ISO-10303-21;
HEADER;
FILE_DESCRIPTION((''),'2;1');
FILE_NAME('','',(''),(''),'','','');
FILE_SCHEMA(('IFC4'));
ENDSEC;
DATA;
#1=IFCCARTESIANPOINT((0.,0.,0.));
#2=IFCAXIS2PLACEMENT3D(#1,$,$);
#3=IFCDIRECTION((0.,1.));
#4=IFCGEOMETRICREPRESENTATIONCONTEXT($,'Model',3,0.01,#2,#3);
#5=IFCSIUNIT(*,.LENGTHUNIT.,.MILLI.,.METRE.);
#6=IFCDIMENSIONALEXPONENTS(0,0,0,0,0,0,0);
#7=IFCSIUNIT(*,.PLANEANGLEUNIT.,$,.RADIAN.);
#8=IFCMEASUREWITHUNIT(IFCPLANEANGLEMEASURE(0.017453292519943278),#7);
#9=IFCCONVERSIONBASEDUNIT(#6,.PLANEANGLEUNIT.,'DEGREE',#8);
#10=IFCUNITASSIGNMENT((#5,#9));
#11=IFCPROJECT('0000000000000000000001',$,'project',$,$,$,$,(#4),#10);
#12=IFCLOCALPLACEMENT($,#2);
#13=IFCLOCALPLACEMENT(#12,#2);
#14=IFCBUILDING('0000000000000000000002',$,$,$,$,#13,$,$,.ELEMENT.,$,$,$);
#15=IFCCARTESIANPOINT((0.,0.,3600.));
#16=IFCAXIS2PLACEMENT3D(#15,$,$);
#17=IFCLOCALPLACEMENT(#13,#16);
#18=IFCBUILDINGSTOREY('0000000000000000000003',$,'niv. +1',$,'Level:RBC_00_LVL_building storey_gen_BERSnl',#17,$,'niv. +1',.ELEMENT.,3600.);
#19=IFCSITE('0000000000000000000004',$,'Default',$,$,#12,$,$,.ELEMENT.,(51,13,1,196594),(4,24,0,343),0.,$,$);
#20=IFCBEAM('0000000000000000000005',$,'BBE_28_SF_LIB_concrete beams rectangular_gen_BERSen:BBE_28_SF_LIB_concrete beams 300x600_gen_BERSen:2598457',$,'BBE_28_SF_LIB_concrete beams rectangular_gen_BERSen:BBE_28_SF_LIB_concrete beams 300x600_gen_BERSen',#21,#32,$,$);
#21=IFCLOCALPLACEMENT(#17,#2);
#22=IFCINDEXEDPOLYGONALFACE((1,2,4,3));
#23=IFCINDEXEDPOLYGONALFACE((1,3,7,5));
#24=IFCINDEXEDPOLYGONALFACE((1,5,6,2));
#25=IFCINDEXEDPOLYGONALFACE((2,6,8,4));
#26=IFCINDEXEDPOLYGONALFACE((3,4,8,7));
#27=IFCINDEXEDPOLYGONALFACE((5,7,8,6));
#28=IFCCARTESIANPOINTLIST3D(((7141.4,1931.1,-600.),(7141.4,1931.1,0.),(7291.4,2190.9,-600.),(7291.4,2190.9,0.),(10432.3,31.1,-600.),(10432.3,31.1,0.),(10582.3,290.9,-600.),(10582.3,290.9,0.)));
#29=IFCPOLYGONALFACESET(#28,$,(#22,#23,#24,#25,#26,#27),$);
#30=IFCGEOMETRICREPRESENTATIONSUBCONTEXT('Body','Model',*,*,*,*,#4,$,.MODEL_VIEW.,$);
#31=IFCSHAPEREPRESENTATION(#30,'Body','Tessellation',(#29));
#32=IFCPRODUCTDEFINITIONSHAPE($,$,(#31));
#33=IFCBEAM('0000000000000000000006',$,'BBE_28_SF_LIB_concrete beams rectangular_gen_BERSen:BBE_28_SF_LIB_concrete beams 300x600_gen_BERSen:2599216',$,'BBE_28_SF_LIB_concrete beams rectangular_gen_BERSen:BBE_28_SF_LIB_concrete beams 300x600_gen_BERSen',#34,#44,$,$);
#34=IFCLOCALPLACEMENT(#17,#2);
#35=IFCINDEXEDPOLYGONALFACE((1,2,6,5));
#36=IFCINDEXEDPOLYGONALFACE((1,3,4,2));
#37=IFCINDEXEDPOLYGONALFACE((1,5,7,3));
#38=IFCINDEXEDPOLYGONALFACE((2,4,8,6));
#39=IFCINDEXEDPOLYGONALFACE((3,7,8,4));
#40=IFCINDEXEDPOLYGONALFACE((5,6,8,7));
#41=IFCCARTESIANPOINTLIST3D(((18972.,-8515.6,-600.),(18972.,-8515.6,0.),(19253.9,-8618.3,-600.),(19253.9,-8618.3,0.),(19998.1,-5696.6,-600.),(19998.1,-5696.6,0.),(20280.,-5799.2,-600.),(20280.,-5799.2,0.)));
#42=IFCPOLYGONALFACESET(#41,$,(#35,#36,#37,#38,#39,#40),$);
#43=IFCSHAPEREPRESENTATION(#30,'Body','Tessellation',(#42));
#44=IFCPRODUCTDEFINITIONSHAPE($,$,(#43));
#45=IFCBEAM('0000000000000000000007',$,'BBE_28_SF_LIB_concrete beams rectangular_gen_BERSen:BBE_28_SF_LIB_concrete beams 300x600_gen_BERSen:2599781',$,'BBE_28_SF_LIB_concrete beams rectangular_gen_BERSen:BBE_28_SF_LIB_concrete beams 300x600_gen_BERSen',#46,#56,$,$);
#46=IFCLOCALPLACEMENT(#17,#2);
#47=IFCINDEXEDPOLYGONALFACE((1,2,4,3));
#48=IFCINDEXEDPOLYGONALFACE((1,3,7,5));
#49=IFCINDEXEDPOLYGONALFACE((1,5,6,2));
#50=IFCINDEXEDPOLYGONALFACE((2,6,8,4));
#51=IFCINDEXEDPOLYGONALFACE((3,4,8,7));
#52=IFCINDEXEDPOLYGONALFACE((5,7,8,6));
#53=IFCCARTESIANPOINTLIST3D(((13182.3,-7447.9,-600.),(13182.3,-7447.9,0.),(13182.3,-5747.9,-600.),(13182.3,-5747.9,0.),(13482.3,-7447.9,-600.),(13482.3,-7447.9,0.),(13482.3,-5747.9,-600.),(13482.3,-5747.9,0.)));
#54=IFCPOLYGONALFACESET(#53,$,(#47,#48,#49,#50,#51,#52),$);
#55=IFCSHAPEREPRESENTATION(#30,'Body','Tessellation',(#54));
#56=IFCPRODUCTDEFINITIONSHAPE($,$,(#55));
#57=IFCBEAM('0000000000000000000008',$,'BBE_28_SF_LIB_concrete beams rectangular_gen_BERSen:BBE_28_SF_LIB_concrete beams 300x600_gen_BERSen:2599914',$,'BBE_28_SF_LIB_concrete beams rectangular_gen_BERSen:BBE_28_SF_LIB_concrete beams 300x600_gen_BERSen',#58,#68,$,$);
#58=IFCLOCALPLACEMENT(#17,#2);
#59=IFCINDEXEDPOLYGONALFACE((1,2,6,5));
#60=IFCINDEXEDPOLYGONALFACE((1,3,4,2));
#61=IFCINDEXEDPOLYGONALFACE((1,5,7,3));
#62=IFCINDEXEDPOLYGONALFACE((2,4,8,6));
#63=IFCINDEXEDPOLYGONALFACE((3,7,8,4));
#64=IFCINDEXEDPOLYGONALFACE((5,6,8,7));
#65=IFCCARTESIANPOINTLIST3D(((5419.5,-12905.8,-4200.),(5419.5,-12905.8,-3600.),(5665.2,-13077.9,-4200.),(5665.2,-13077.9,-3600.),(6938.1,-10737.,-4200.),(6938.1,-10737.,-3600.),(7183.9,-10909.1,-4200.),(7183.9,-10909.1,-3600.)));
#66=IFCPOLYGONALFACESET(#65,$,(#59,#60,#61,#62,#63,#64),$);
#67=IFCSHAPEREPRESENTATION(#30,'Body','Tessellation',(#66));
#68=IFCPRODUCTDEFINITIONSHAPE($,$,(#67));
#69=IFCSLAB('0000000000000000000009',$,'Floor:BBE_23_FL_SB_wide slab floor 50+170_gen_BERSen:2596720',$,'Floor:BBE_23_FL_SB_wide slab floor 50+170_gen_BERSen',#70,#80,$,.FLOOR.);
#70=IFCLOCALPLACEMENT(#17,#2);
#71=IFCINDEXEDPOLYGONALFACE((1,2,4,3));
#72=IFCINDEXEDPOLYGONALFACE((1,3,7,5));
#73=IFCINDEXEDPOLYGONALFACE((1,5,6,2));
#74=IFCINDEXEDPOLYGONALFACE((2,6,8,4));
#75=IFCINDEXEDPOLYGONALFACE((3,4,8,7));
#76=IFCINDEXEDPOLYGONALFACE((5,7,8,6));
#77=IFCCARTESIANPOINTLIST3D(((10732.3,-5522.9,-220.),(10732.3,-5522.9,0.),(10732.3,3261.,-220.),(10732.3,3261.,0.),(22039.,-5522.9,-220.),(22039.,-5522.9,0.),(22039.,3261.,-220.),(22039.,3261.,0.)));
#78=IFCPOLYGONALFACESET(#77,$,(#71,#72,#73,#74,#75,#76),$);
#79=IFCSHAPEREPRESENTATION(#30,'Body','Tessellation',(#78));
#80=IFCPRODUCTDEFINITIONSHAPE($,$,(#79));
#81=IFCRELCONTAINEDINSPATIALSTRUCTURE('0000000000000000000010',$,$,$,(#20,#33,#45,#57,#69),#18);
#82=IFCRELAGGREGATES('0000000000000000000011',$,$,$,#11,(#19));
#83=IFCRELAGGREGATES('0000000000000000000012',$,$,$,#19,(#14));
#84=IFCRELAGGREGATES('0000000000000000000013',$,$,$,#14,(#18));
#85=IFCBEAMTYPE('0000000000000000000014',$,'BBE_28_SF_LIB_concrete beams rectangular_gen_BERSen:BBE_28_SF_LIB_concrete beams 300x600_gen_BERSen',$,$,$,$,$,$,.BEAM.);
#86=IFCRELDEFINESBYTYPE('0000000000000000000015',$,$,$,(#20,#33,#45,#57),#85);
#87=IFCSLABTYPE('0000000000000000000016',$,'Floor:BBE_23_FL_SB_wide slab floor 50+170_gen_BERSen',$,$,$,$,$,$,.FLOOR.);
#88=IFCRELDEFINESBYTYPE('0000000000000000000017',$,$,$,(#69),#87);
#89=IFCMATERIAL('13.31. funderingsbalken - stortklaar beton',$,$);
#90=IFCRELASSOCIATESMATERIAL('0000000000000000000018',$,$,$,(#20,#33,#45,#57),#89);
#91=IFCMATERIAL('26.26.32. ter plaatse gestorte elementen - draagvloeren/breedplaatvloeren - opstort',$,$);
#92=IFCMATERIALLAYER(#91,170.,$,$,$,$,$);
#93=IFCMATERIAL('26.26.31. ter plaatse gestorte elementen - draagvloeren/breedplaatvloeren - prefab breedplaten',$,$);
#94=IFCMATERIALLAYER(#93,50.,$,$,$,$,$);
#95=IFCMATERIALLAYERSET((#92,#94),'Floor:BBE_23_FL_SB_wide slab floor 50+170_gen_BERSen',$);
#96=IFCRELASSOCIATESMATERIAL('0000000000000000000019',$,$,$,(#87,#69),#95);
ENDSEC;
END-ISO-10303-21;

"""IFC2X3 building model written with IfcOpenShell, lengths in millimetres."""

from ifc_helpers import new_model, entity, si_unit, converted_unit, direction, frame, frame_2d, origin, place, context, subcontext, project, spatial, rectangle, extrude, material, layer, layer_set, layer_usage, type_object, element, save


model = new_model("IFC2X3")

# Units and contexts
model_context = context("Model", 3, precision=0.01, world=origin(), true_north=direction((0.0, 1.0)))
body_context = subcontext(model_context, "Body", "Model", "MODEL_VIEW")
ifc_project = project(units=[si_unit("LENGTHUNIT", "METRE", prefix="MILLI"), converted_unit("PLANEANGLEUNIT", "DEGREE", entity("IfcPlaneAngleMeasure", 0.017453292519943278), si_unit("PLANEANGLEUNIT", "RADIAN"), dimensions=[0, 0, 0, 0, 0, 0, 0])], contexts=[model_context])

# Site, building, storey
site_placement = place(None, origin())
site = spatial("IfcSite", under=ifc_project, at=site_placement, Name="Default", CompositionType="ELEMENT", RefLatitude=(51, 13, 1, 196594), RefLongitude=(4, 24, 0, 343), RefElevation=0.0)
building_placement = place(site_placement, origin())
building = spatial("IfcBuilding", under=site, at=building_placement, CompositionType="ELEMENT")
storey_placement = place(building_placement, frame((0.0, 0.0, 3600.0)))
storey = spatial("IfcBuildingStorey", under=building, at=storey_placement, Name="niv. +1", ObjectType="Level:RBC_00_LVL_building storey_gen_BERSnl", LongName="niv. +1", CompositionType="ELEMENT", Elevation=3600.0)

# Beams
ifc_material_1 = material(Name="13.31. funderingsbalken - stortklaar beton")
beam_type = type_object("IfcBeamType", Name="BBE_28_SF_LIB_concrete beams rectangular_gen_BERSen:BBE_28_SF_LIB_concrete beams 300x600_gen_BERSen", PredefinedType="BEAM")
beam_1_placement = place(storey_placement, frame((10507.3, 161.0, 0.0), z_axis=(0.0, 0.0, 1.0), x_axis=(-0.866025, 0.5, 0.0)))
element("IfcBeam", 1, at=beam_1_placement, inside=storey, type_object=beam_type, material=ifc_material_1, Name="BBE_28_SF_LIB_concrete beams rectangular_gen_BERSen:BBE_28_SF_LIB_concrete beams 300x600_gen_BERSen:2598457", ObjectType="BBE_28_SF_LIB_concrete beams rectangular_gen_BERSen:BBE_28_SF_LIB_concrete beams 300x600_gen_BERSen", context=body_context, shape_type="SweptSolid", body=[
    extrude(rectangle(XDim=600.0, YDim=300.0, at=frame_2d((0.0, 0.0), x_axis=(1.0, 0.0))), frame((0.0, 0.0, -300.0), z_axis=(1.0, 0.0, 0.0), x_axis=(0.0, 0.0, -1.0)), (0.0, 0.0, 1.0), 3800.0),
])
beam_2_placement = place(storey_placement, frame((20139.0, -5747.9, 0.0), z_axis=(0.0, 0.0, 1.0), x_axis=(-0.34202, -0.939693, 0.0)))
element("IfcBeam", 2, at=beam_2_placement, inside=storey, type_object=beam_type, material=ifc_material_1, Name="BBE_28_SF_LIB_concrete beams rectangular_gen_BERSen:BBE_28_SF_LIB_concrete beams 300x600_gen_BERSen:2599216", ObjectType="BBE_28_SF_LIB_concrete beams rectangular_gen_BERSen:BBE_28_SF_LIB_concrete beams 300x600_gen_BERSen", context=body_context, shape_type="SweptSolid", body=[
    extrude(rectangle(XDim=600.0, YDim=300.0, at=frame_2d((0.0, 0.0), x_axis=(1.0, 0.0))), frame((0.0, 0.0, -300.0), z_axis=(1.0, 0.0, 0.0), x_axis=(0.0, 0.0, -1.0)), (0.0, 0.0, 1.0), 3000.0),
])
beam_3_placement = place(storey_placement, frame((13332.3, -5747.9, 0.0), z_axis=(0.0, 0.0, 1.0), x_axis=(0.0, -1.0, 0.0)))
element("IfcBeam", 3, at=beam_3_placement, inside=storey, type_object=beam_type, material=ifc_material_1, Name="BBE_28_SF_LIB_concrete beams rectangular_gen_BERSen:BBE_28_SF_LIB_concrete beams 300x600_gen_BERSen:2599781", ObjectType="BBE_28_SF_LIB_concrete beams rectangular_gen_BERSen:BBE_28_SF_LIB_concrete beams 300x600_gen_BERSen", context=body_context, shape_type="SweptSolid", body=[
    extrude(rectangle(XDim=600.0, YDim=300.0, at=frame_2d((0.0, 0.0), x_axis=(1.0, 0.0))), frame((0.0, 0.0, -300.0), z_axis=(1.0, 0.0, 0.0), x_axis=(0.0, 0.0, -1.0)), (0.0, 0.0, 1.0), 1700.0),
])
beam_4_placement = place(storey_placement, frame((7061.0, -10823.1, -3600.0), z_axis=(0.0, 0.0, 1.0), x_axis=(-0.573576, -0.819152, 0.0)))
element("IfcBeam", 4, at=beam_4_placement, inside=storey, type_object=beam_type, material=ifc_material_1, Name="BBE_28_SF_LIB_concrete beams rectangular_gen_BERSen:BBE_28_SF_LIB_concrete beams 300x600_gen_BERSen:2599914", ObjectType="BBE_28_SF_LIB_concrete beams rectangular_gen_BERSen:BBE_28_SF_LIB_concrete beams 300x600_gen_BERSen", context=body_context, shape_type="SweptSolid", body=[
    extrude(rectangle(XDim=600.0, YDim=300.0, at=frame_2d((0.0, 0.0), x_axis=(1.0, 0.0))), frame((0.0, 0.0, -300.0), z_axis=(1.0, 0.0, 0.0), x_axis=(0.0, 0.0, -1.0)), (0.0, 0.0, 1.0), 2647.6),
])

# Slab
ifc_material_2 = material(Name="26.26.32. ter plaatse gestorte elementen - draagvloeren/breedplaatvloeren - opstort")
ifc_layer_1 = layer(ifc_material_2, 170.0)
ifc_material_3 = material(Name="26.26.31. ter plaatse gestorte elementen - draagvloeren/breedplaatvloeren - prefab breedplaten")
ifc_layer_2 = layer(ifc_material_3, 50.0)
ifc_layer_set = layer_set([ifc_layer_1, ifc_layer_2], Name="Floor:BBE_23_FL_SB_wide slab floor 50+170_gen_BERSen")
ifc_layer_usage = layer_usage(ifc_layer_set, "AXIS3", "POSITIVE", 0.0)
slab_type = type_object("IfcSlabType", Name="Floor:BBE_23_FL_SB_wide slab floor 50+170_gen_BERSen", PredefinedType="FLOOR", material=ifc_layer_set)
slab_placement = place(storey_placement, origin())
element("IfcSlab", 5, at=slab_placement, inside=storey, type_object=slab_type, material=ifc_layer_usage, Name="Floor:BBE_23_FL_SB_wide slab floor 50+170_gen_BERSen:2596720", ObjectType="Floor:BBE_23_FL_SB_wide slab floor 50+170_gen_BERSen", PredefinedType="FLOOR", context=body_context, shape_type="SweptSolid", body=[
    extrude(rectangle(XDim=8783.9, YDim=11306.7, at=frame_2d((0.0, 0.0), x_axis=(1.0, 0.0))), frame((16385.6, -1130.9, 0.0), z_axis=(0.0, 0.0, -1.0), x_axis=(0.0, 1.0, 0.0)), (0.0, 0.0, 1.0), 220.0),
])

save(model, "model.ifc")
